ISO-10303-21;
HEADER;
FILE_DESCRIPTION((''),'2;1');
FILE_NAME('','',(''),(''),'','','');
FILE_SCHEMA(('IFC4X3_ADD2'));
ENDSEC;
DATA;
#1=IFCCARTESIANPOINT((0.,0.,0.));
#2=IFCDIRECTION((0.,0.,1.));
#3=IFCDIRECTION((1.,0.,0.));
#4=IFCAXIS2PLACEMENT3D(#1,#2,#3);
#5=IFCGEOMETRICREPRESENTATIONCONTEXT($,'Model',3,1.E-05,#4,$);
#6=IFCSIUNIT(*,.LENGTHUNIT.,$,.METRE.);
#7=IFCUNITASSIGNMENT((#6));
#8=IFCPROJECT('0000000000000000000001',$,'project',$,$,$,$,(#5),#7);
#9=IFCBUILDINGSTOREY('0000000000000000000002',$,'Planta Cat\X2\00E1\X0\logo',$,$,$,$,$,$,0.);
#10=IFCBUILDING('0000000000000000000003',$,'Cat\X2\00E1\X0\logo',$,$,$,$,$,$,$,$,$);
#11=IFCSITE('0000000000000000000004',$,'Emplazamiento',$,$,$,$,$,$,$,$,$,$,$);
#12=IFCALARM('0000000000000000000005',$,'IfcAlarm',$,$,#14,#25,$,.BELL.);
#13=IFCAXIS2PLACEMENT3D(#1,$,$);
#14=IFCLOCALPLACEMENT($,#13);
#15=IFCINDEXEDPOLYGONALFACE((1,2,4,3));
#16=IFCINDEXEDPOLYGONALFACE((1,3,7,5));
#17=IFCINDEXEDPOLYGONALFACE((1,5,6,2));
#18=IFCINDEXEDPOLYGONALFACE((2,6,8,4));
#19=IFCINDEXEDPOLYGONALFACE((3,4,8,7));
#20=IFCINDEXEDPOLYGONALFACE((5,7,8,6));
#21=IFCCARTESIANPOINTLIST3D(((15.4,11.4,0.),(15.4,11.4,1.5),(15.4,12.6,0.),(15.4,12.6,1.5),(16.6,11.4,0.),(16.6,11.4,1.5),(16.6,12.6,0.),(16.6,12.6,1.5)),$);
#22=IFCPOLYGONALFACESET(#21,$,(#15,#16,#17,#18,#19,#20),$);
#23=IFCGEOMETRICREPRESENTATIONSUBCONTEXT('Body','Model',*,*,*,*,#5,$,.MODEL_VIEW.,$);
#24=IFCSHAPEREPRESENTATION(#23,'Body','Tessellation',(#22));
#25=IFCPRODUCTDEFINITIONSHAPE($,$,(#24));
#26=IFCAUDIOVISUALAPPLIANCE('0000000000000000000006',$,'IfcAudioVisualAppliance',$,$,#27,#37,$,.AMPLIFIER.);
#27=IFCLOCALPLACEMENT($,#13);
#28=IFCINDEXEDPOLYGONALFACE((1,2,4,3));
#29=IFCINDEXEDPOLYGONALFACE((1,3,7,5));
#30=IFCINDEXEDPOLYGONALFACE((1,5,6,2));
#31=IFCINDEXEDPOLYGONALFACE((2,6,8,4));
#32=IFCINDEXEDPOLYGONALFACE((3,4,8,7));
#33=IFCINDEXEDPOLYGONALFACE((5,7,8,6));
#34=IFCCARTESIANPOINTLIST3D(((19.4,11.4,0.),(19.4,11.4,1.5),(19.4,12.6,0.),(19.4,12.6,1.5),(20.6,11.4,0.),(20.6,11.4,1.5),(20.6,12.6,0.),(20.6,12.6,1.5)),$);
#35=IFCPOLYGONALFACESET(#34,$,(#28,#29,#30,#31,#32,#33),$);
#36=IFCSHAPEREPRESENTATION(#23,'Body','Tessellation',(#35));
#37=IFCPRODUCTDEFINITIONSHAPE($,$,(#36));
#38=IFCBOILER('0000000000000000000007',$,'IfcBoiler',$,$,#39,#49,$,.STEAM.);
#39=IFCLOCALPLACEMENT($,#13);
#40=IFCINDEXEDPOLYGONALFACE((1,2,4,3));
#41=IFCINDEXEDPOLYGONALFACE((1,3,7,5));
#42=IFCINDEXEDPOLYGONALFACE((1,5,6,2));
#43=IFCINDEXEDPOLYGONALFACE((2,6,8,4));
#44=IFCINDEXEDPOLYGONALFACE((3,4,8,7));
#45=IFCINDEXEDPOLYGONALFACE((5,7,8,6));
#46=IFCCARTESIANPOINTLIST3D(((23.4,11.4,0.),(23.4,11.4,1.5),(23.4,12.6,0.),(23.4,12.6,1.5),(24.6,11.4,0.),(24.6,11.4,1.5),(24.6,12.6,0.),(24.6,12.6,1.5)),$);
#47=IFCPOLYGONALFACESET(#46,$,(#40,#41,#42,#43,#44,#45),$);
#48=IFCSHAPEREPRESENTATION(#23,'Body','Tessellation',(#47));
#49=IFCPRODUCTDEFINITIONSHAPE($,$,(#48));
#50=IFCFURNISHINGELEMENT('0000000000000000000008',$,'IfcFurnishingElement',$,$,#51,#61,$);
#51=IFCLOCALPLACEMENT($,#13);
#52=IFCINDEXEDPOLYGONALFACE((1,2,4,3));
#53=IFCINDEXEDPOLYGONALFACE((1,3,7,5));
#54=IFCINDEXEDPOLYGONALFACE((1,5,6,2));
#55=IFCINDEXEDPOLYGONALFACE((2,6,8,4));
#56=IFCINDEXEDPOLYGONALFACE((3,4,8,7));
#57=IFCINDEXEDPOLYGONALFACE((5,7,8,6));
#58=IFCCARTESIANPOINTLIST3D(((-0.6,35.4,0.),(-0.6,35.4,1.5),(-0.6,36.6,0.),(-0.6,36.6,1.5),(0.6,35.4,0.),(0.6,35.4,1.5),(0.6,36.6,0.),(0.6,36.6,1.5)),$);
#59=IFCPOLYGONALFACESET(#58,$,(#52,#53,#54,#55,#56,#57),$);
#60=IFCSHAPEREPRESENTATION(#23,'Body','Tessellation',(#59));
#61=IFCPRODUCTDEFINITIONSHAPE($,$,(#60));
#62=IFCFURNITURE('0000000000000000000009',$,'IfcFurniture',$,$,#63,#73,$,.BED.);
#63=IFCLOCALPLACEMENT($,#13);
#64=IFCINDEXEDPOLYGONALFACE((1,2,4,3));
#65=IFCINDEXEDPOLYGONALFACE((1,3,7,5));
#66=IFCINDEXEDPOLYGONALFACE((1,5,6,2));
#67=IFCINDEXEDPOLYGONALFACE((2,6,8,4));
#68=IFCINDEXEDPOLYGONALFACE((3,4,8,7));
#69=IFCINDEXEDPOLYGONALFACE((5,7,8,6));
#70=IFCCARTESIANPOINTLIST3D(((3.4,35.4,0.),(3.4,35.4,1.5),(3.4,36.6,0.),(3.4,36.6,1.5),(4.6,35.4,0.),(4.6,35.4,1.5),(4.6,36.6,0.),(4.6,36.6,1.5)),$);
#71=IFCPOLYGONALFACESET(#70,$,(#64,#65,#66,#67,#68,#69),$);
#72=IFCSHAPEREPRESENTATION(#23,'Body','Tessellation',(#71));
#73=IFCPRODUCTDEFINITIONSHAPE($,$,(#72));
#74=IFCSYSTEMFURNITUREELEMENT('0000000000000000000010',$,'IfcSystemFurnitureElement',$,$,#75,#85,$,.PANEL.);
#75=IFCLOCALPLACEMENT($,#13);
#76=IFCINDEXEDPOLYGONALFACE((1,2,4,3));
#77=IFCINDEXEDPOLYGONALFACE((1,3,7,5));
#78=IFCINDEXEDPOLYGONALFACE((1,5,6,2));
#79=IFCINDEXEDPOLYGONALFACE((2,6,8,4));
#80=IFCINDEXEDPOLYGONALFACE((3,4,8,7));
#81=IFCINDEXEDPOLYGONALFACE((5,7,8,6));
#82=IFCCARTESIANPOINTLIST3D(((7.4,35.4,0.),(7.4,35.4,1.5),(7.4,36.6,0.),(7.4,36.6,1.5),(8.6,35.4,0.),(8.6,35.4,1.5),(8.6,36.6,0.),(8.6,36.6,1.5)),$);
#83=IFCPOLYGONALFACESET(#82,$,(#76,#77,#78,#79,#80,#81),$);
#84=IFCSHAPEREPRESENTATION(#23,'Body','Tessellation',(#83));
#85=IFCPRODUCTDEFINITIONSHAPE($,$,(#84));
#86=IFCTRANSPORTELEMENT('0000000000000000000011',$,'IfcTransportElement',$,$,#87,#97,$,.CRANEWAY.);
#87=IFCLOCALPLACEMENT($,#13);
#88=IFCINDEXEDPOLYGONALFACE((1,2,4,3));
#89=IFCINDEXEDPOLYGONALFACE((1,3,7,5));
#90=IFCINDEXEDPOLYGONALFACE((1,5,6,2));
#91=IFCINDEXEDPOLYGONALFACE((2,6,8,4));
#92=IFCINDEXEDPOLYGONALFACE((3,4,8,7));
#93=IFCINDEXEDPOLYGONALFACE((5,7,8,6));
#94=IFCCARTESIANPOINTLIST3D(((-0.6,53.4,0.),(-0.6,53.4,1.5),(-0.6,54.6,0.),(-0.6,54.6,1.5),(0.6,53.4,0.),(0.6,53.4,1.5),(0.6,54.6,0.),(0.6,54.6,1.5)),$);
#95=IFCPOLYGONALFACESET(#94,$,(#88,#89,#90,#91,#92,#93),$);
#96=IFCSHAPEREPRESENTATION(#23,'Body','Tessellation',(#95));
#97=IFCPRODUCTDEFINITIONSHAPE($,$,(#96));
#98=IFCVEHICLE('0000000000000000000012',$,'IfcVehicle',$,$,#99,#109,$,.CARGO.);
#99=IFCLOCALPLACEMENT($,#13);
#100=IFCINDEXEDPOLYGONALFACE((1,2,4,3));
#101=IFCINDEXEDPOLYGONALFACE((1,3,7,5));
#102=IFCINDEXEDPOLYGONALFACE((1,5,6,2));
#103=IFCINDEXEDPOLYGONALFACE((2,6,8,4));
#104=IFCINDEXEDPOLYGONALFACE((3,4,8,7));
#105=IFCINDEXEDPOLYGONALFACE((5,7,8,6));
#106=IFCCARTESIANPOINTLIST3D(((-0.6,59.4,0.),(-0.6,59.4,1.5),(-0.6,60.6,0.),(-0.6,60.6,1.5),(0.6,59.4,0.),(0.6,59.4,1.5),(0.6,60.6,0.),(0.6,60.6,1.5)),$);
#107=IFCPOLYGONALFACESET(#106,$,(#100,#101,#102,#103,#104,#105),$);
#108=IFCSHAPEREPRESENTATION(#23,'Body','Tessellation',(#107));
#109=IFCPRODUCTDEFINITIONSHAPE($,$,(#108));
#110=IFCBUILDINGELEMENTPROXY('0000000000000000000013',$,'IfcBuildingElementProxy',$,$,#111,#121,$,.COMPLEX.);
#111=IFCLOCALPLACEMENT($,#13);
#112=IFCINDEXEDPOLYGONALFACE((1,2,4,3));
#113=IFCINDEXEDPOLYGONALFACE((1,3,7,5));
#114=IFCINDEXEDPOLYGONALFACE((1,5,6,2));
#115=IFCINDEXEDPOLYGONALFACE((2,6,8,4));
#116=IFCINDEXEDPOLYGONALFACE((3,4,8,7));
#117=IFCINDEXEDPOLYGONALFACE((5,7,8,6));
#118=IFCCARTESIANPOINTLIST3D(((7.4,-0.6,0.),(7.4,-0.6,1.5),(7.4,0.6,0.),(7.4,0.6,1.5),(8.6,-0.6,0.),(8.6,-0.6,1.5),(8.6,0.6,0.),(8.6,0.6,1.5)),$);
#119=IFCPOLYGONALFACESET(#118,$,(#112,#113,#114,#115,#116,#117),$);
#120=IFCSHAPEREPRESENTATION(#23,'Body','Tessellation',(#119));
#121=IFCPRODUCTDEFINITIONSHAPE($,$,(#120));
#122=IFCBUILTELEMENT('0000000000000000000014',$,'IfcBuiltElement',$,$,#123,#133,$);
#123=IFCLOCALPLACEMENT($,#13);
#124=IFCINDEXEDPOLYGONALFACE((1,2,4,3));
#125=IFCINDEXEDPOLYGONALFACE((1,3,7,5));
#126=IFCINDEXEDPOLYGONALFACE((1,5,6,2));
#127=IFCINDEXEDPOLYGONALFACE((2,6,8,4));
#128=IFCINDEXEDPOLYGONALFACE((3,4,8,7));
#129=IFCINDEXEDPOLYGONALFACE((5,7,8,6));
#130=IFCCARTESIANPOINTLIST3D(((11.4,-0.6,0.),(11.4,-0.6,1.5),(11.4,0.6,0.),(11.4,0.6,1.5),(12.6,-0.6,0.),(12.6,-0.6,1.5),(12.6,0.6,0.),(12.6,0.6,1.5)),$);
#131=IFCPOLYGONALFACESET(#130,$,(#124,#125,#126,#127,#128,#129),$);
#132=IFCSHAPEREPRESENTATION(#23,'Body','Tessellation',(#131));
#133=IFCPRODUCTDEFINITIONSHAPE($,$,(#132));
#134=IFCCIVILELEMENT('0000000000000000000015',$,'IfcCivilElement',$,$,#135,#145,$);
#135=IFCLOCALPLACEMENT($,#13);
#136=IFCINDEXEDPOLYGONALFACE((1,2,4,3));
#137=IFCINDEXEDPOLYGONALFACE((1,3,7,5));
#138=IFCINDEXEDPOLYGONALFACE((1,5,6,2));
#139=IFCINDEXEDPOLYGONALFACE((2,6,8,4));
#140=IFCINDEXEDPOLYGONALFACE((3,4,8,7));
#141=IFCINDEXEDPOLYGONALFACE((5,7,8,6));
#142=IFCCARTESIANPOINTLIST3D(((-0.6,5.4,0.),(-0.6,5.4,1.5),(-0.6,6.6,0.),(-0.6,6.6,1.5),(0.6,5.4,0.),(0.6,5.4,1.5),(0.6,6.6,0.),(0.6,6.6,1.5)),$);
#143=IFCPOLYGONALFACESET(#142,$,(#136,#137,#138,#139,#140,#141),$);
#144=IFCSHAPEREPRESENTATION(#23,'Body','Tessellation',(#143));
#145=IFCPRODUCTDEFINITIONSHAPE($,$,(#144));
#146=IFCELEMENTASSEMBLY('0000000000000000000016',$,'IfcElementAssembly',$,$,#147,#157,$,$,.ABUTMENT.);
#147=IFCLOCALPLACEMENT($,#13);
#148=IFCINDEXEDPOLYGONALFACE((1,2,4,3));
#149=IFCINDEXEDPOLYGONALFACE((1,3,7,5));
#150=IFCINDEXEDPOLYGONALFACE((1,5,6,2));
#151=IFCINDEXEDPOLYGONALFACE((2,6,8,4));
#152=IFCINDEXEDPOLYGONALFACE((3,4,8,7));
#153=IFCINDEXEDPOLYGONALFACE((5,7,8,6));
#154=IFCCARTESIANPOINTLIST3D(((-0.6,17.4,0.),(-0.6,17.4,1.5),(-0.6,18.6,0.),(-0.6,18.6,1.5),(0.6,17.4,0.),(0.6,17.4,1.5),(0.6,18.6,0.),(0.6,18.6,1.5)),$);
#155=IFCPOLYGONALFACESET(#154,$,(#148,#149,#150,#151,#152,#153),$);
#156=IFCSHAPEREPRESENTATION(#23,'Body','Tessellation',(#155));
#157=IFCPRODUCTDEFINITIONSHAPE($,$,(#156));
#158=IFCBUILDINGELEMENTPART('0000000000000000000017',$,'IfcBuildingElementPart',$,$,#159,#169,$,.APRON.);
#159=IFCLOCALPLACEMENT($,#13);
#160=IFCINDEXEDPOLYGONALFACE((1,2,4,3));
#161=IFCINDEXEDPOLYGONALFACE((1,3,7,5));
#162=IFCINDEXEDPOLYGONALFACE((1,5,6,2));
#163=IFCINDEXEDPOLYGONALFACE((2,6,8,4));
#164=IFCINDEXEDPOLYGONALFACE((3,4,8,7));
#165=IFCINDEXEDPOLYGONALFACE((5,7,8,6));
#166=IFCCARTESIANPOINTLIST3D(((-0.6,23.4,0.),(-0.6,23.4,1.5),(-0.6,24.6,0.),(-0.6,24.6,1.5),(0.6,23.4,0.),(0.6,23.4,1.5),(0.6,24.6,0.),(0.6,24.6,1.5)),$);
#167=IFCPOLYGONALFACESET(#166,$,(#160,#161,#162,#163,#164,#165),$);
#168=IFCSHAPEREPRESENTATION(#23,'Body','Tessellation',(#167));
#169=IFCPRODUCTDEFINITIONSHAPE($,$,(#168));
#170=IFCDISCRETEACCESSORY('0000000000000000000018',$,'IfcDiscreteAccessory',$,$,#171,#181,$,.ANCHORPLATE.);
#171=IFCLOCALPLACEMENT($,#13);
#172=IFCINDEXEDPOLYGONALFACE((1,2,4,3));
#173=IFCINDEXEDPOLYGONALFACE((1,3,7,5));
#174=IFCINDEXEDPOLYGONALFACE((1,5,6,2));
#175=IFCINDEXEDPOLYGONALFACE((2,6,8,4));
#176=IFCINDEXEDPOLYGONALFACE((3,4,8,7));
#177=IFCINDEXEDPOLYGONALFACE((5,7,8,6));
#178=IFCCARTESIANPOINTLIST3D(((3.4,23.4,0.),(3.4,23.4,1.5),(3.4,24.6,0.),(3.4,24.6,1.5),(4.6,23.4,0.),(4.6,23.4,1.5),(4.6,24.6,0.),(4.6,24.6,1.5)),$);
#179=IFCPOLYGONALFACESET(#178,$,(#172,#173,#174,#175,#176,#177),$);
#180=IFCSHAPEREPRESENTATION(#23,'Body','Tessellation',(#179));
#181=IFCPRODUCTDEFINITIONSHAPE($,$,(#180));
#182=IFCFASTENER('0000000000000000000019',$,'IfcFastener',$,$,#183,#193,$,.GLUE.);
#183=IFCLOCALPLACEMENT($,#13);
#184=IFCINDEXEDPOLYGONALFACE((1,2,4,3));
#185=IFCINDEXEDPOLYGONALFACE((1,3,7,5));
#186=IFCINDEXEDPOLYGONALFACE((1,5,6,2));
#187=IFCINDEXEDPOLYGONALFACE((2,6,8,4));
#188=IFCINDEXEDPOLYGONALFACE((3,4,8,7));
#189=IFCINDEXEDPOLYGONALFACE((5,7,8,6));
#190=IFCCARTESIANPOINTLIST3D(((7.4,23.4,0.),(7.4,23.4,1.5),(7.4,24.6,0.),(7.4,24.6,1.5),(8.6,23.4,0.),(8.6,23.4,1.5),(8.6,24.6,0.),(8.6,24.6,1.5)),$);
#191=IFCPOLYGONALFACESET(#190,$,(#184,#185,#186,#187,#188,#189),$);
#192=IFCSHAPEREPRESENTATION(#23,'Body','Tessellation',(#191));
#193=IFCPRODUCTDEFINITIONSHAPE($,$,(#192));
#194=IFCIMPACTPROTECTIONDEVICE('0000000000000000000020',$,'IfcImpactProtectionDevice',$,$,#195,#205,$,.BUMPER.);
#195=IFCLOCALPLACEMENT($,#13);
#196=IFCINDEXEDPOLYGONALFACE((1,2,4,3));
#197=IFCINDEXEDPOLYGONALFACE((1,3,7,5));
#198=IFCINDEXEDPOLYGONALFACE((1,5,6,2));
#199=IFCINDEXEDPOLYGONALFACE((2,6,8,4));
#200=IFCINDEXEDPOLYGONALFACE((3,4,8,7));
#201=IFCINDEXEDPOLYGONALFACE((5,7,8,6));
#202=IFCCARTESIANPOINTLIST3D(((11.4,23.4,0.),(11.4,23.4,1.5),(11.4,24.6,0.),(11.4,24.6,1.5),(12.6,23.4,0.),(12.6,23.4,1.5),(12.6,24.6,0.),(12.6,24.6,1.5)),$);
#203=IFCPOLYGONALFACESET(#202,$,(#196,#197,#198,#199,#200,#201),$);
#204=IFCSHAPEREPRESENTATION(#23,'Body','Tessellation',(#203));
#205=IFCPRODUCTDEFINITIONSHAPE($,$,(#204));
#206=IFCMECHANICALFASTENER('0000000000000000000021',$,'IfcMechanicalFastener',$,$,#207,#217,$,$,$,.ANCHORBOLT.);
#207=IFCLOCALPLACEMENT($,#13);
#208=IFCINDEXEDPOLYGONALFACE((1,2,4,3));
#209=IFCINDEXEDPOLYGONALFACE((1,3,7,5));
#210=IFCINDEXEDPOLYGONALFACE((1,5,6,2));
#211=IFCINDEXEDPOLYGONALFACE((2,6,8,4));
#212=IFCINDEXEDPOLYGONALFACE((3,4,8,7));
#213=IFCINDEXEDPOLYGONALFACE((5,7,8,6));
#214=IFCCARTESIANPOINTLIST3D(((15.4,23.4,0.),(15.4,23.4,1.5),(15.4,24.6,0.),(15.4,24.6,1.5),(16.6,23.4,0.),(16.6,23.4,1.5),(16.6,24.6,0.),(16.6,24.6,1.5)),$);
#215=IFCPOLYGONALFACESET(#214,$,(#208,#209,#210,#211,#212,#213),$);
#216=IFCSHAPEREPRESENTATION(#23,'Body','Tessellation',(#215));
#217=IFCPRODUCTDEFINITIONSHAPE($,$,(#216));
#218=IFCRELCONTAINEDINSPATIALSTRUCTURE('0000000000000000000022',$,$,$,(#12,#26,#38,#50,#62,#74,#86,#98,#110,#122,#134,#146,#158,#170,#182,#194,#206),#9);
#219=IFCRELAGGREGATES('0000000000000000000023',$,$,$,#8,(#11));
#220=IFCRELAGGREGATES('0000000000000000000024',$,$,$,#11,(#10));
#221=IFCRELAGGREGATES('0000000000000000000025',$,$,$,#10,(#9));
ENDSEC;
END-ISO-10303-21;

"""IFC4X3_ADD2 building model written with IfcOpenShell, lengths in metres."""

from ifc_helpers import new_model, si_unit, frame, origin, origin_with_axes, origin_2d, place, context, subcontext, project, spatial, rectangle, extrude, element, save


model = new_model("IFC4X3_ADD2")

# Units and contexts
model_context = context("Model", 3, precision=1e-05, world=origin_with_axes())
body_context = subcontext(model_context, "Body", "Model", "MODEL_VIEW")
ifc_project = project(units=[si_unit("LENGTHUNIT", "METRE")], contexts=[model_context])

# Site, building, storey
site = spatial("IfcSite", under=ifc_project, Name="Emplazamiento")
building = spatial("IfcBuilding", under=site, Name="Catálogo")
storey = spatial("IfcBuildingStorey", under=building, Name="Planta Catálogo", Elevation=0.0)

# Alarm
alarm_placement = place(None, frame((16.0, 12.0, 0.0), z_axis=(0.0, 0.0, 1.0), x_axis=(1.0, 0.0, 0.0)))
element("IfcAlarm", 1, at=alarm_placement, inside=storey, Name="IfcAlarm", PredefinedType="BELL", context=body_context, shape_type="SweptSolid", body=[
    extrude(rectangle(XDim=1.2, YDim=1.2, at=origin_2d()), origin(), (0.0, 0.0, 1.0), 1.5),
])

# Audio visual appliance
audio_visual_appliance_placement = place(None, frame((20.0, 12.0, 0.0), z_axis=(0.0, 0.0, 1.0), x_axis=(1.0, 0.0, 0.0)))
element("IfcAudioVisualAppliance", 2, at=audio_visual_appliance_placement, inside=storey, Name="IfcAudioVisualAppliance", PredefinedType="AMPLIFIER", context=body_context, shape_type="SweptSolid", body=[
    extrude(rectangle(XDim=1.2, YDim=1.2, at=origin_2d()), origin(), (0.0, 0.0, 1.0), 1.5),
])

# Boiler
boiler_placement = place(None, frame((24.0, 12.0, 0.0), z_axis=(0.0, 0.0, 1.0), x_axis=(1.0, 0.0, 0.0)))
element("IfcBoiler", 3, at=boiler_placement, inside=storey, Name="IfcBoiler", PredefinedType="STEAM", context=body_context, shape_type="SweptSolid", body=[
    extrude(rectangle(XDim=1.2, YDim=1.2, at=origin_2d()), origin(), (0.0, 0.0, 1.0), 1.5),
])

# Furnishing element
furnishing_placement = place(None, frame((0.0, 36.0, 0.0), z_axis=(0.0, 0.0, 1.0), x_axis=(1.0, 0.0, 0.0)))
element("IfcFurnishingElement", 4, at=furnishing_placement, inside=storey, Name="IfcFurnishingElement", context=body_context, shape_type="SweptSolid", body=[
    extrude(rectangle(XDim=1.2, YDim=1.2, at=origin_2d()), origin(), (0.0, 0.0, 1.0), 1.5),
])

# Furniture
furniture_placement = place(None, frame((4.0, 36.0, 0.0), z_axis=(0.0, 0.0, 1.0), x_axis=(1.0, 0.0, 0.0)))
element("IfcFurniture", 5, at=furniture_placement, inside=storey, Name="IfcFurniture", PredefinedType="BED", context=body_context, shape_type="SweptSolid", body=[
    extrude(rectangle(XDim=1.2, YDim=1.2, at=origin_2d()), origin(), (0.0, 0.0, 1.0), 1.5),
])

# System furniture element
system_furniture_element_placement = place(None, frame((8.0, 36.0, 0.0), z_axis=(0.0, 0.0, 1.0), x_axis=(1.0, 0.0, 0.0)))
element("IfcSystemFurnitureElement", 6, at=system_furniture_element_placement, inside=storey, Name="IfcSystemFurnitureElement", PredefinedType="PANEL", context=body_context, shape_type="SweptSolid", body=[
    extrude(rectangle(XDim=1.2, YDim=1.2, at=origin_2d()), origin(), (0.0, 0.0, 1.0), 1.5),
])

# Transport element
transport_element_placement = place(None, frame((0.0, 54.0, 0.0), z_axis=(0.0, 0.0, 1.0), x_axis=(1.0, 0.0, 0.0)))
element("IfcTransportElement", 7, at=transport_element_placement, inside=storey, Name="IfcTransportElement", PredefinedType="CRANEWAY", context=body_context, shape_type="SweptSolid", body=[
    extrude(rectangle(XDim=1.2, YDim=1.2, at=origin_2d()), origin(), (0.0, 0.0, 1.0), 1.5),
])

# Vehicle
vehicle_placement = place(None, frame((0.0, 60.0, 0.0), z_axis=(0.0, 0.0, 1.0), x_axis=(1.0, 0.0, 0.0)))
element("IfcVehicle", 8, at=vehicle_placement, inside=storey, Name="IfcVehicle", PredefinedType="CARGO", context=body_context, shape_type="SweptSolid", body=[
    extrude(rectangle(XDim=1.2, YDim=1.2, at=origin_2d()), origin(), (0.0, 0.0, 1.0), 1.5),
])

# Building element proxy
proxy_placement = place(None, frame((8.0, 0.0, 0.0), z_axis=(0.0, 0.0, 1.0), x_axis=(1.0, 0.0, 0.0)))
element("IfcBuildingElementProxy", 9, at=proxy_placement, inside=storey, Name="IfcBuildingElementProxy", PredefinedType="COMPLEX", context=body_context, shape_type="SweptSolid", body=[
    extrude(rectangle(XDim=1.2, YDim=1.2, at=origin_2d()), origin(), (0.0, 0.0, 1.0), 1.5),
])

# Built element
built_element_placement = place(None, frame((12.0, 0.0, 0.0), z_axis=(0.0, 0.0, 1.0), x_axis=(1.0, 0.0, 0.0)))
element("IfcBuiltElement", 10, at=built_element_placement, inside=storey, Name="IfcBuiltElement", context=body_context, shape_type="SweptSolid", body=[
    extrude(rectangle(XDim=1.2, YDim=1.2, at=origin_2d()), origin(), (0.0, 0.0, 1.0), 1.5),
])

# Civil element
civil_element_placement = place(None, frame((0.0, 6.0, 0.0), z_axis=(0.0, 0.0, 1.0), x_axis=(1.0, 0.0, 0.0)))
element("IfcCivilElement", 11, at=civil_element_placement, inside=storey, Name="IfcCivilElement", context=body_context, shape_type="SweptSolid", body=[
    extrude(rectangle(XDim=1.2, YDim=1.2, at=origin_2d()), origin(), (0.0, 0.0, 1.0), 1.5),
])

# Element assembly
assembly_placement = place(None, frame((0.0, 18.0, 0.0), z_axis=(0.0, 0.0, 1.0), x_axis=(1.0, 0.0, 0.0)))
element("IfcElementAssembly", 12, at=assembly_placement, inside=storey, Name="IfcElementAssembly", PredefinedType="ABUTMENT", context=body_context, shape_type="SweptSolid", body=[
    extrude(rectangle(XDim=1.2, YDim=1.2, at=origin_2d()), origin(), (0.0, 0.0, 1.0), 1.5),
])

# Building element part
building_element_part_placement = place(None, frame((0.0, 24.0, 0.0), z_axis=(0.0, 0.0, 1.0), x_axis=(1.0, 0.0, 0.0)))
element("IfcBuildingElementPart", 13, at=building_element_part_placement, inside=storey, Name="IfcBuildingElementPart", PredefinedType="APRON", context=body_context, shape_type="SweptSolid", body=[
    extrude(rectangle(XDim=1.2, YDim=1.2, at=origin_2d()), origin(), (0.0, 0.0, 1.0), 1.5),
])

# Discrete accessory
discrete_accessory_placement = place(None, frame((4.0, 24.0, 0.0), z_axis=(0.0, 0.0, 1.0), x_axis=(1.0, 0.0, 0.0)))
element("IfcDiscreteAccessory", 14, at=discrete_accessory_placement, inside=storey, Name="IfcDiscreteAccessory", PredefinedType="ANCHORPLATE", context=body_context, shape_type="SweptSolid", body=[
    extrude(rectangle(XDim=1.2, YDim=1.2, at=origin_2d()), origin(), (0.0, 0.0, 1.0), 1.5),
])

# Fastener
fastener_placement = place(None, frame((8.0, 24.0, 0.0), z_axis=(0.0, 0.0, 1.0), x_axis=(1.0, 0.0, 0.0)))
element("IfcFastener", 15, at=fastener_placement, inside=storey, Name="IfcFastener", PredefinedType="GLUE", context=body_context, shape_type="SweptSolid", body=[
    extrude(rectangle(XDim=1.2, YDim=1.2, at=origin_2d()), origin(), (0.0, 0.0, 1.0), 1.5),
])

# Impact protection device
impact_protection_device_placement = place(None, frame((12.0, 24.0, 0.0), z_axis=(0.0, 0.0, 1.0), x_axis=(1.0, 0.0, 0.0)))
element("IfcImpactProtectionDevice", 16, at=impact_protection_device_placement, inside=storey, Name="IfcImpactProtectionDevice", PredefinedType="BUMPER", context=body_context, shape_type="SweptSolid", body=[
    extrude(rectangle(XDim=1.2, YDim=1.2, at=origin_2d()), origin(), (0.0, 0.0, 1.0), 1.5),
])

# Mechanical fastener
mechanical_fastener_placement = place(None, frame((16.0, 24.0, 0.0), z_axis=(0.0, 0.0, 1.0), x_axis=(1.0, 0.0, 0.0)))
element("IfcMechanicalFastener", 17, at=mechanical_fastener_placement, inside=storey, Name="IfcMechanicalFastener", PredefinedType="ANCHORBOLT", context=body_context, shape_type="SweptSolid", body=[
    extrude(rectangle(XDim=1.2, YDim=1.2, at=origin_2d()), origin(), (0.0, 0.0, 1.0), 1.5),
])

save(model, "model.ifc")
